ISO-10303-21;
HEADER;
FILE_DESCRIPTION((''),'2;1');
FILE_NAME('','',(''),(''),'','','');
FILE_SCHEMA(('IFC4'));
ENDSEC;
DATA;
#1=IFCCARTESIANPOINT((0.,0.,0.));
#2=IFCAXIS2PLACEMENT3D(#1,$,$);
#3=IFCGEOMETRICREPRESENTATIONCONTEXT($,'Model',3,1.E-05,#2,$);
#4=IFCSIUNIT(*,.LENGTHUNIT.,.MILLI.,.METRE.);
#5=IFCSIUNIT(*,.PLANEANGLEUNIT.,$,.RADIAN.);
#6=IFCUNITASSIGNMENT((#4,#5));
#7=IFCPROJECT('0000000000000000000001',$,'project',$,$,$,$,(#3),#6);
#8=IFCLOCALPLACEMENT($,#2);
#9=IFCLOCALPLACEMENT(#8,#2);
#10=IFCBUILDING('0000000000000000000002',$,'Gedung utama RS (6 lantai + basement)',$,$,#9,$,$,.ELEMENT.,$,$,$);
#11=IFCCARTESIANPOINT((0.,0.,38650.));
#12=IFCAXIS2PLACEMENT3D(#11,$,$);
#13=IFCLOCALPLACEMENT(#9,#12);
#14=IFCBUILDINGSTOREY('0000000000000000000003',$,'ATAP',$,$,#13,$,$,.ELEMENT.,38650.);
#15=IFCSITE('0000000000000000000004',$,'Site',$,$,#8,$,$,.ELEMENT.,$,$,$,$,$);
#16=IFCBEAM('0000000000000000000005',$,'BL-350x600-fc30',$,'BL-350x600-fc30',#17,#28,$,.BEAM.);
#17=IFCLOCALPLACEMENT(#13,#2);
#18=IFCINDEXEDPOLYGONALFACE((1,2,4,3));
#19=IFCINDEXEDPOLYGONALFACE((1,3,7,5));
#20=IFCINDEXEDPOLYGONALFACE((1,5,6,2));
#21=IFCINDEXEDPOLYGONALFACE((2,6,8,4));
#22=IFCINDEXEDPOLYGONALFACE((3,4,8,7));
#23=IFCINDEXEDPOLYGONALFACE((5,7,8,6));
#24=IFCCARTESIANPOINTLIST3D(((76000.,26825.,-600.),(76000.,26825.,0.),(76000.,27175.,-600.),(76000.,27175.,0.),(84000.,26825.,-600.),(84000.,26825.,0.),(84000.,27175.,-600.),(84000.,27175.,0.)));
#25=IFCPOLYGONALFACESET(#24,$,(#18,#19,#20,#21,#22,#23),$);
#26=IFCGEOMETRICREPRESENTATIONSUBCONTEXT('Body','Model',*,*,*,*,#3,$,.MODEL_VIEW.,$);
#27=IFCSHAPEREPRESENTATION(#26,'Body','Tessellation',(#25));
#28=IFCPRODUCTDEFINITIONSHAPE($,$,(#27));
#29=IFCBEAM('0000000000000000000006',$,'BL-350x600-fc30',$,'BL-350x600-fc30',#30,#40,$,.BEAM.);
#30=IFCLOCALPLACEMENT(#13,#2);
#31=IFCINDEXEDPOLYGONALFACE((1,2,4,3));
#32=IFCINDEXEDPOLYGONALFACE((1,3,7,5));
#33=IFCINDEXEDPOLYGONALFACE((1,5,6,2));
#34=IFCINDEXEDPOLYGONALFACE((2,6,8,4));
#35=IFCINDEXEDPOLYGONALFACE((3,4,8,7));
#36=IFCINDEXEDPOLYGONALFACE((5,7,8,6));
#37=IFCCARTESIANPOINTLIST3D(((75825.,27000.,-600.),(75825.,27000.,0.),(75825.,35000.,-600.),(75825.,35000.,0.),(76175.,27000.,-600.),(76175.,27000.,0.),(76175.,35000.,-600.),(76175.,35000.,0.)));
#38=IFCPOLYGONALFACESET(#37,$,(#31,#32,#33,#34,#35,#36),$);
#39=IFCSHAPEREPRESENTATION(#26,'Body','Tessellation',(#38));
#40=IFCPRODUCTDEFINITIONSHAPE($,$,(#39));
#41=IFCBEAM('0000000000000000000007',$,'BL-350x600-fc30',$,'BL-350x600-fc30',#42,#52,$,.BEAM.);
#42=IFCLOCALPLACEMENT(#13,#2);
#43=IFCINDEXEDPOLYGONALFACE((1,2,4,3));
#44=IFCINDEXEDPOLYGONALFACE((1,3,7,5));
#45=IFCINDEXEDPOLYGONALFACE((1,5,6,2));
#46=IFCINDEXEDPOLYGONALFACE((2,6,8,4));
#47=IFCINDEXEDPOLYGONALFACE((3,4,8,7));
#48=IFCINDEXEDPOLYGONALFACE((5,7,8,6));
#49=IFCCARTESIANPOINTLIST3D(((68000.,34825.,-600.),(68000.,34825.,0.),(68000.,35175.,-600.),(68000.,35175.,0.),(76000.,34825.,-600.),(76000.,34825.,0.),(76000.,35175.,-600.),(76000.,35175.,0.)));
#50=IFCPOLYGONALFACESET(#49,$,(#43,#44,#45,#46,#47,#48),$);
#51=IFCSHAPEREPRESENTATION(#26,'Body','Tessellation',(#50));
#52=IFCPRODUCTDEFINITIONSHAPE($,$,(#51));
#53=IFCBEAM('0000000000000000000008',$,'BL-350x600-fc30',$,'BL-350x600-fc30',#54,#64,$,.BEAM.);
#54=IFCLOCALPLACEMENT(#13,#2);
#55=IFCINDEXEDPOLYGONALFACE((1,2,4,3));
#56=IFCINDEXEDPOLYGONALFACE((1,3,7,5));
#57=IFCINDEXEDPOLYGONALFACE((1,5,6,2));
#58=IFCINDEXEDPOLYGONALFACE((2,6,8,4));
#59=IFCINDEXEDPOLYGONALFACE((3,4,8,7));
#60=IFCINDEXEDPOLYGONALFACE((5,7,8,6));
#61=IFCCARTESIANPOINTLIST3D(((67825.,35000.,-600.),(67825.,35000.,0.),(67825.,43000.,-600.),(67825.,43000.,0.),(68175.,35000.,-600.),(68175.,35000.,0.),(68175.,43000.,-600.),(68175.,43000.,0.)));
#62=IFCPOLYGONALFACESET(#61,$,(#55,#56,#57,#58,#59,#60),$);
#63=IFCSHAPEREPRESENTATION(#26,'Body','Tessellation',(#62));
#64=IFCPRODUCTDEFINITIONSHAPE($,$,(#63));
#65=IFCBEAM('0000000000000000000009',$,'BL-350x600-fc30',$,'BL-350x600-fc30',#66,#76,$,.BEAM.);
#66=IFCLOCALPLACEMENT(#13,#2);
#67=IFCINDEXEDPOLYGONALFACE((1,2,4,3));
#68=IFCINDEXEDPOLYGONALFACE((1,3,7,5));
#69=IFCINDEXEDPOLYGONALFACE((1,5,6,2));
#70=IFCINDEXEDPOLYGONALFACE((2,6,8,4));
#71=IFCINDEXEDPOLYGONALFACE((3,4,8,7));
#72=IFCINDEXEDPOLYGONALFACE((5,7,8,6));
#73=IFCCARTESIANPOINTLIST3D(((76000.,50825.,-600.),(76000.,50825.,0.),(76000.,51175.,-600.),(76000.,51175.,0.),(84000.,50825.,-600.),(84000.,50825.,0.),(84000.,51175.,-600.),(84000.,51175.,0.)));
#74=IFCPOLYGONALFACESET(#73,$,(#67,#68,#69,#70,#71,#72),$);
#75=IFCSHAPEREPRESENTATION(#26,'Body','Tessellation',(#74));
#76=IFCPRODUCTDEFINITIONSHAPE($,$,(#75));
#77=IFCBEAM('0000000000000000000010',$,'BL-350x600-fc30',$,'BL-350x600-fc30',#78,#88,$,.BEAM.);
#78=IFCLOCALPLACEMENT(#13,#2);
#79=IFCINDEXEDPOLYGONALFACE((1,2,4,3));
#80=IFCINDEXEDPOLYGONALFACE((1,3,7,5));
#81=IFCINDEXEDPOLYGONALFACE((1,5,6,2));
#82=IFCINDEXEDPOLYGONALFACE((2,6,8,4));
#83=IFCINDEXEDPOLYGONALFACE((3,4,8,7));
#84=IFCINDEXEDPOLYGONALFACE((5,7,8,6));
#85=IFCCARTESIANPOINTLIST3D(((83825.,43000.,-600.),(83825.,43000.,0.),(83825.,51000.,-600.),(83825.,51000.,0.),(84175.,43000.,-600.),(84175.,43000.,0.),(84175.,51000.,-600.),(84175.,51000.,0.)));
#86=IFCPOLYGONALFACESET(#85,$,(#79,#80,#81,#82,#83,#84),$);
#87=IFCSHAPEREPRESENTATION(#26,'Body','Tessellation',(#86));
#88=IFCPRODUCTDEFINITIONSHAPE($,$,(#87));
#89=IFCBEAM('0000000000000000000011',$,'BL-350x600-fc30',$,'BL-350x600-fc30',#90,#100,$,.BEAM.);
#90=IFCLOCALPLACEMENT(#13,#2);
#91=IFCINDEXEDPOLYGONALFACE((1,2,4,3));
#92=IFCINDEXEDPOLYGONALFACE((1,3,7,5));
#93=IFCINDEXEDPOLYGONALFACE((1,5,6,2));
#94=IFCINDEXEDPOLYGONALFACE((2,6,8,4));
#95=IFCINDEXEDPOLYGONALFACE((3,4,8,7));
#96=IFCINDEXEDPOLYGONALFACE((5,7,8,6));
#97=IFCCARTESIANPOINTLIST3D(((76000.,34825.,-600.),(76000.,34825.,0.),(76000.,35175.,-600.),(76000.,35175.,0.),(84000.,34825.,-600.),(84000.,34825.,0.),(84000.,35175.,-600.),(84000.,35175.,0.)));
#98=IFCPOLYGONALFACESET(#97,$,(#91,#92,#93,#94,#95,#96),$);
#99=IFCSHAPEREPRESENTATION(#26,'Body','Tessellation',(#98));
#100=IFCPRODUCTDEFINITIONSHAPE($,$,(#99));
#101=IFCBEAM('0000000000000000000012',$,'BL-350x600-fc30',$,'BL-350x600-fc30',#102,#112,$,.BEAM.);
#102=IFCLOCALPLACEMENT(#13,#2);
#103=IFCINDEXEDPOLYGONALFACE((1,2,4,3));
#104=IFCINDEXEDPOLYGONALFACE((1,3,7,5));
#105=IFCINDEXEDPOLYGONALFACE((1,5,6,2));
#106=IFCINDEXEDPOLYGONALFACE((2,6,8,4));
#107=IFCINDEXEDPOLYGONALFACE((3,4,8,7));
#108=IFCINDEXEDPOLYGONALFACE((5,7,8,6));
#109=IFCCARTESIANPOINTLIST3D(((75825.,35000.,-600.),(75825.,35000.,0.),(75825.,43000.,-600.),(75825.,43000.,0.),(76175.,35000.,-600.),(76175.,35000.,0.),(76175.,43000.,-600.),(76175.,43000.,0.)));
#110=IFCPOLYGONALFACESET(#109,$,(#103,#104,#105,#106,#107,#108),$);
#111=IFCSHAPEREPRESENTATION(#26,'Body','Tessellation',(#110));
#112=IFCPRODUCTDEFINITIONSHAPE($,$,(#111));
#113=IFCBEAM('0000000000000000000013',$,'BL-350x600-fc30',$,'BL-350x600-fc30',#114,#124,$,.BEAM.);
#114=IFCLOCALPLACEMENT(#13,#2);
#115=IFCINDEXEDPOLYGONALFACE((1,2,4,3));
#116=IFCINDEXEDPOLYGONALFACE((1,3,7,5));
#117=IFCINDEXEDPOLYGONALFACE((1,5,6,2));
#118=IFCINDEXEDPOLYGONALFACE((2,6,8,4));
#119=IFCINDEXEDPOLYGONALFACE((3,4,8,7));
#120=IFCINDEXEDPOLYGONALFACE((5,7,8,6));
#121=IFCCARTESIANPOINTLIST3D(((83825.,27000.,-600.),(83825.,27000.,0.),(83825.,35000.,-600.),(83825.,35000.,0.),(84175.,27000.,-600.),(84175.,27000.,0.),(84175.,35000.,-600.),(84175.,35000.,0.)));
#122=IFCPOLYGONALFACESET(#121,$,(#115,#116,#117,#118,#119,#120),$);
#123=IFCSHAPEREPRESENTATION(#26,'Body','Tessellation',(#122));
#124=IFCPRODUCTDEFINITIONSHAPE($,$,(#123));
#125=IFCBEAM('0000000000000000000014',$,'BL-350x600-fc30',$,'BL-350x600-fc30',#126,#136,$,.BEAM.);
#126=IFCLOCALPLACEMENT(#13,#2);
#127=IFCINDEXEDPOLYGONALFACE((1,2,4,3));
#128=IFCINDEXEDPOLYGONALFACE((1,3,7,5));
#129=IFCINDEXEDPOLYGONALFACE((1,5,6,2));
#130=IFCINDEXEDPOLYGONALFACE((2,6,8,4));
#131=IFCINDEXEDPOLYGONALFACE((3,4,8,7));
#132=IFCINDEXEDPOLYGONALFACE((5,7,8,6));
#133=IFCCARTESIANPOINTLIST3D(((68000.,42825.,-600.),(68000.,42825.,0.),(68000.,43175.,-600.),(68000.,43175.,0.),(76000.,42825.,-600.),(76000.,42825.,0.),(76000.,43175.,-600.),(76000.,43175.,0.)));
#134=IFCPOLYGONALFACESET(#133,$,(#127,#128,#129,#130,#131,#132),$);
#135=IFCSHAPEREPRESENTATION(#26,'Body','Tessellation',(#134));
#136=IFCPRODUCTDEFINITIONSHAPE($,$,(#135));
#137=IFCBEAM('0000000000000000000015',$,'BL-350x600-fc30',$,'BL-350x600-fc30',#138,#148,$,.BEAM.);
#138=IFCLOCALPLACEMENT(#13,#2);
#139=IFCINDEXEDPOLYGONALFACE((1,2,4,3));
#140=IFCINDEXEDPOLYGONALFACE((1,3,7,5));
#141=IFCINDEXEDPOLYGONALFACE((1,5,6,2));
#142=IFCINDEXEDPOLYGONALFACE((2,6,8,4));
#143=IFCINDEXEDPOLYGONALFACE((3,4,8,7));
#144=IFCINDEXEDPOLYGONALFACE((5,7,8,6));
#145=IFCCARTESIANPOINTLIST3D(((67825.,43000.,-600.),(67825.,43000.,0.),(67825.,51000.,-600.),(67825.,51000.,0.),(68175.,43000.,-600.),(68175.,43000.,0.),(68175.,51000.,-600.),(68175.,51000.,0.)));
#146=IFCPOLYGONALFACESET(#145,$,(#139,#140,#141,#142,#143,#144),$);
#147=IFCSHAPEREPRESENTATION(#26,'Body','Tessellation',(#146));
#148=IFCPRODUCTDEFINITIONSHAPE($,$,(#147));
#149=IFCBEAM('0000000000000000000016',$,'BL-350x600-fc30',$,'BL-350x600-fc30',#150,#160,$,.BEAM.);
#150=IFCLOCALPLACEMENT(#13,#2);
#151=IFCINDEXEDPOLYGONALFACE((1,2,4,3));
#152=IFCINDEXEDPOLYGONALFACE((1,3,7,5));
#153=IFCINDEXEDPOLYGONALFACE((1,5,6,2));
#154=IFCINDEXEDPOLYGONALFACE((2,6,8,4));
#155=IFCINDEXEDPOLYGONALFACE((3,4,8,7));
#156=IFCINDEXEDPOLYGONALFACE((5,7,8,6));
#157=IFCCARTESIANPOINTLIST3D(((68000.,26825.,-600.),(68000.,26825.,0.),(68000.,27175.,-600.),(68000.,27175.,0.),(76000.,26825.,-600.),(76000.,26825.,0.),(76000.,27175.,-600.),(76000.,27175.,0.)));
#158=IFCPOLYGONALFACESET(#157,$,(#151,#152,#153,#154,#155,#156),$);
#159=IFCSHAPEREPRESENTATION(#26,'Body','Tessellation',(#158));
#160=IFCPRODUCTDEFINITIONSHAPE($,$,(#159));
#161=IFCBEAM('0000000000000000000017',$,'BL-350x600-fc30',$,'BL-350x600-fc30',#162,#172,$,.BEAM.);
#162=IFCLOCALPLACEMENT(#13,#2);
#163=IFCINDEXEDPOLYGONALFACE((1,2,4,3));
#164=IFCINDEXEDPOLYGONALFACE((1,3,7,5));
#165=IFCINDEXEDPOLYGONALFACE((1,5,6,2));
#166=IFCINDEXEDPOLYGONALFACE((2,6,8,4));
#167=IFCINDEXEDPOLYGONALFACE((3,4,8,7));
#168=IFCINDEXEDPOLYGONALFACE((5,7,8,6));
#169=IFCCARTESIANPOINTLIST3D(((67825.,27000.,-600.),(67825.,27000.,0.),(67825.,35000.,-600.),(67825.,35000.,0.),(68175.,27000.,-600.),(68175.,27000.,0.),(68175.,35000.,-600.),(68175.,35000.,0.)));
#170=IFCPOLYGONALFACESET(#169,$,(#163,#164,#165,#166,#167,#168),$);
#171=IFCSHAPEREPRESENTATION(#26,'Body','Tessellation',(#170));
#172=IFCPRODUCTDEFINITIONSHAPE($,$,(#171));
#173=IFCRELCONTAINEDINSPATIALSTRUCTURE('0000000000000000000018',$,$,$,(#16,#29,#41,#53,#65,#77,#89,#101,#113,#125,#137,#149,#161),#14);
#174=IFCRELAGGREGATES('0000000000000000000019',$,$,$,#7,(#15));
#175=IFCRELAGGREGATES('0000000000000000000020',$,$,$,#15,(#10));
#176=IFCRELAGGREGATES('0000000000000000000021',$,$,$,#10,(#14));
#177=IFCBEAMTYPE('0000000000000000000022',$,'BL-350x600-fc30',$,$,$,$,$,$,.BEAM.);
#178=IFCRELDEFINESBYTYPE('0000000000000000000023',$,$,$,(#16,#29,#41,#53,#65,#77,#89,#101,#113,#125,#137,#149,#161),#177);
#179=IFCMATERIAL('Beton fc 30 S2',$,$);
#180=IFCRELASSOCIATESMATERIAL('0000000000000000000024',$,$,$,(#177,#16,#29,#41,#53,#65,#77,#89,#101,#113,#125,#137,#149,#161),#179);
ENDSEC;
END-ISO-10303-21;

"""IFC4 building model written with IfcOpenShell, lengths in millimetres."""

from ifc_helpers import new_model, si_unit, frame, origin, origin_2d, place, context, subcontext, project, spatial, rectangle, extrude, material, material_profile, profile_set, profile_usage, type_object, element, save


model = new_model("IFC4")

# Units and contexts
model_context = context("Model", 3, precision=1e-05, world=origin())
body_context = subcontext(model_context, "Body", "Model", "MODEL_VIEW")
ifc_project = project(units=[si_unit("LENGTHUNIT", "METRE", prefix="MILLI"), si_unit("PLANEANGLEUNIT", "RADIAN")], contexts=[model_context])

# Site, building, storey
site_placement = place(None, origin())
site = spatial("IfcSite", under=ifc_project, at=site_placement, Name="Site", CompositionType="ELEMENT")
building_placement = place(site_placement, origin())
building = spatial("IfcBuilding", under=site, at=building_placement, Name="Gedung utama RS (6 lantai + basement)", CompositionType="ELEMENT")
storey_placement = place(building_placement, frame((0.0, 0.0, 38650.0)))
storey = spatial("IfcBuildingStorey", under=building, at=storey_placement, Name="ATAP", CompositionType="ELEMENT", Elevation=38650.0)

# Beams
ifc_material = material(Name="Beton fc 30 S2")
ifc_material_profile_1 = material_profile(ifc_material, rectangle(XDim=350.0, YDim=600.0, at=origin_2d()), Name="BL-350x600-fc30")
ifc_profile_set_1 = profile_set([ifc_material_profile_1], Name="BL-350x600-fc30")
ifc_profile_usage_1 = profile_usage(ifc_profile_set_1, cardinal=8)
beam_type = type_object("IfcBeamType", Name="BL-350x600-fc30", PredefinedType="BEAM", material=ifc_profile_set_1)
beam_1_placement = place(storey_placement, frame((76000.0, 27000.0, -300.0)))
element("IfcBeam", 1, at=beam_1_placement, inside=storey, type_object=beam_type, material=ifc_profile_usage_1, Name="BL-350x600-fc30", ObjectType="BL-350x600-fc30", PredefinedType="BEAM", context=body_context, shape_type="SweptSolid", body=[
    extrude(rectangle(XDim=350.0, YDim=600.0, at=origin_2d()), frame((0.0, 0.0, 0.0), z_axis=(1.0, 0.0, 0.0), x_axis=(0.0, 1.0, 0.0)), (0.0, 0.0, 1.0), 8000.0),
])
beam_2_placement = place(storey_placement, frame((76000.0, 27000.0, -300.0)))
element("IfcBeam", 2, at=beam_2_placement, inside=storey, type_object=beam_type, material=ifc_profile_usage_1, Name="BL-350x600-fc30", ObjectType="BL-350x600-fc30", PredefinedType="BEAM", context=body_context, shape_type="SweptSolid", body=[
    extrude(rectangle(XDim=350.0, YDim=600.0, at=origin_2d()), frame((0.0, 0.0, 0.0), z_axis=(0.0, 1.0, 0.0), x_axis=(-1.0, 0.0, 0.0)), (0.0, 0.0, 1.0), 8000.0),
])
beam_3_placement = place(storey_placement, frame((68000.0, 35000.0, -300.0)))
element("IfcBeam", 3, at=beam_3_placement, inside=storey, type_object=beam_type, material=ifc_profile_usage_1, Name="BL-350x600-fc30", ObjectType="BL-350x600-fc30", PredefinedType="BEAM", context=body_context, shape_type="SweptSolid", body=[
    extrude(rectangle(XDim=350.0, YDim=600.0, at=origin_2d()), frame((0.0, 0.0, 0.0), z_axis=(1.0, 0.0, 0.0), x_axis=(0.0, 1.0, 0.0)), (0.0, 0.0, 1.0), 8000.0),
])
beam_4_placement = place(storey_placement, frame((68000.0, 35000.0, -300.0)))
element("IfcBeam", 4, at=beam_4_placement, inside=storey, type_object=beam_type, material=ifc_profile_usage_1, Name="BL-350x600-fc30", ObjectType="BL-350x600-fc30", PredefinedType="BEAM", context=body_context, shape_type="SweptSolid", body=[
    extrude(rectangle(XDim=350.0, YDim=600.0, at=origin_2d()), frame((0.0, 0.0, 0.0), z_axis=(0.0, 1.0, 0.0), x_axis=(-1.0, 0.0, 0.0)), (0.0, 0.0, 1.0), 8000.0),
])
beam_5_placement = place(storey_placement, frame((76000.0, 51000.0, -300.0)))
element("IfcBeam", 5, at=beam_5_placement, inside=storey, type_object=beam_type, material=ifc_profile_usage_1, Name="BL-350x600-fc30", ObjectType="BL-350x600-fc30", PredefinedType="BEAM", context=body_context, shape_type="SweptSolid", body=[
    extrude(rectangle(XDim=350.0, YDim=600.0, at=origin_2d()), frame((0.0, 0.0, 0.0), z_axis=(1.0, 0.0, 0.0), x_axis=(0.0, 1.0, 0.0)), (0.0, 0.0, 1.0), 8000.0),
])
beam_6_placement = place(storey_placement, frame((84000.0, 43000.0, -300.0)))
element("IfcBeam", 6, at=beam_6_placement, inside=storey, type_object=beam_type, material=ifc_profile_usage_1, Name="BL-350x600-fc30", ObjectType="BL-350x600-fc30", PredefinedType="BEAM", context=body_context, shape_type="SweptSolid", body=[
    extrude(rectangle(XDim=350.0, YDim=600.0, at=origin_2d()), frame((0.0, 0.0, 0.0), z_axis=(0.0, 1.0, 0.0), x_axis=(-1.0, 0.0, 0.0)), (0.0, 0.0, 1.0), 8000.0),
])
beam_7_placement = place(storey_placement, frame((76000.0, 35000.0, -300.0)))
element("IfcBeam", 7, at=beam_7_placement, inside=storey, type_object=beam_type, material=ifc_profile_usage_1, Name="BL-350x600-fc30", ObjectType="BL-350x600-fc30", PredefinedType="BEAM", context=body_context, shape_type="SweptSolid", body=[
    extrude(rectangle(XDim=350.0, YDim=600.0, at=origin_2d()), frame((0.0, 0.0, 0.0), z_axis=(1.0, 0.0, 0.0), x_axis=(0.0, 1.0, 0.0)), (0.0, 0.0, 1.0), 8000.0),
])
for number, where, name in (
    (8, (76000.0, 35000.0, -300.0), "BL-350x600-fc30"),
    (9, (84000.0, 27000.0, -300.0), "BL-350x600-fc30"),
):
    element("IfcBeam", number, at=place(storey_placement, frame(where)), inside=storey, type_object=beam_type, material=ifc_profile_usage_1, Name=name, ObjectType="BL-350x600-fc30", PredefinedType="BEAM", context=body_context, shape_type="SweptSolid", body=[
        extrude(rectangle(XDim=350.0, YDim=600.0, at=origin_2d()), frame((0.0, 0.0, 0.0), z_axis=(0.0, 1.0, 0.0), x_axis=(-1.0, 0.0, 0.0)), (0.0, 0.0, 1.0), 8000.0),
    ])
beam_8_placement = place(storey_placement, frame((68000.0, 43000.0, -300.0)))
element("IfcBeam", 10, at=beam_8_placement, inside=storey, type_object=beam_type, material=ifc_profile_usage_1, Name="BL-350x600-fc30", ObjectType="BL-350x600-fc30", PredefinedType="BEAM", context=body_context, shape_type="SweptSolid", body=[
    extrude(rectangle(XDim=350.0, YDim=600.0, at=origin_2d()), frame((0.0, 0.0, 0.0), z_axis=(1.0, 0.0, 0.0), x_axis=(0.0, 1.0, 0.0)), (0.0, 0.0, 1.0), 8000.0),
])
beam_9_placement = place(storey_placement, frame((68000.0, 43000.0, -300.0)))
element("IfcBeam", 11, at=beam_9_placement, inside=storey, type_object=beam_type, material=ifc_profile_usage_1, Name="BL-350x600-fc30", ObjectType="BL-350x600-fc30", PredefinedType="BEAM", context=body_context, shape_type="SweptSolid", body=[
    extrude(rectangle(XDim=350.0, YDim=600.0, at=origin_2d()), frame((0.0, 0.0, 0.0), z_axis=(0.0, 1.0, 0.0), x_axis=(-1.0, 0.0, 0.0)), (0.0, 0.0, 1.0), 8000.0),
])
beam_10_placement = place(storey_placement, frame((68000.0, 27000.0, -300.0)))
element("IfcBeam", 12, at=beam_10_placement, inside=storey, type_object=beam_type, material=ifc_profile_usage_1, Name="BL-350x600-fc30", ObjectType="BL-350x600-fc30", PredefinedType="BEAM", context=body_context, shape_type="SweptSolid", body=[
    extrude(rectangle(XDim=350.0, YDim=600.0, at=origin_2d()), frame((0.0, 0.0, 0.0), z_axis=(1.0, 0.0, 0.0), x_axis=(0.0, 1.0, 0.0)), (0.0, 0.0, 1.0), 8000.0),
])
beam_11_placement = place(storey_placement, frame((68000.0, 27000.0, -300.0)))
element("IfcBeam", 13, at=beam_11_placement, inside=storey, type_object=beam_type, material=ifc_profile_usage_1, Name="BL-350x600-fc30", ObjectType="BL-350x600-fc30", PredefinedType="BEAM", context=body_context, shape_type="SweptSolid", body=[
    extrude(rectangle(XDim=350.0, YDim=600.0, at=origin_2d()), frame((0.0, 0.0, 0.0), z_axis=(0.0, 1.0, 0.0), x_axis=(-1.0, 0.0, 0.0)), (0.0, 0.0, 1.0), 8000.0),
])

save(model, "model.ifc")
